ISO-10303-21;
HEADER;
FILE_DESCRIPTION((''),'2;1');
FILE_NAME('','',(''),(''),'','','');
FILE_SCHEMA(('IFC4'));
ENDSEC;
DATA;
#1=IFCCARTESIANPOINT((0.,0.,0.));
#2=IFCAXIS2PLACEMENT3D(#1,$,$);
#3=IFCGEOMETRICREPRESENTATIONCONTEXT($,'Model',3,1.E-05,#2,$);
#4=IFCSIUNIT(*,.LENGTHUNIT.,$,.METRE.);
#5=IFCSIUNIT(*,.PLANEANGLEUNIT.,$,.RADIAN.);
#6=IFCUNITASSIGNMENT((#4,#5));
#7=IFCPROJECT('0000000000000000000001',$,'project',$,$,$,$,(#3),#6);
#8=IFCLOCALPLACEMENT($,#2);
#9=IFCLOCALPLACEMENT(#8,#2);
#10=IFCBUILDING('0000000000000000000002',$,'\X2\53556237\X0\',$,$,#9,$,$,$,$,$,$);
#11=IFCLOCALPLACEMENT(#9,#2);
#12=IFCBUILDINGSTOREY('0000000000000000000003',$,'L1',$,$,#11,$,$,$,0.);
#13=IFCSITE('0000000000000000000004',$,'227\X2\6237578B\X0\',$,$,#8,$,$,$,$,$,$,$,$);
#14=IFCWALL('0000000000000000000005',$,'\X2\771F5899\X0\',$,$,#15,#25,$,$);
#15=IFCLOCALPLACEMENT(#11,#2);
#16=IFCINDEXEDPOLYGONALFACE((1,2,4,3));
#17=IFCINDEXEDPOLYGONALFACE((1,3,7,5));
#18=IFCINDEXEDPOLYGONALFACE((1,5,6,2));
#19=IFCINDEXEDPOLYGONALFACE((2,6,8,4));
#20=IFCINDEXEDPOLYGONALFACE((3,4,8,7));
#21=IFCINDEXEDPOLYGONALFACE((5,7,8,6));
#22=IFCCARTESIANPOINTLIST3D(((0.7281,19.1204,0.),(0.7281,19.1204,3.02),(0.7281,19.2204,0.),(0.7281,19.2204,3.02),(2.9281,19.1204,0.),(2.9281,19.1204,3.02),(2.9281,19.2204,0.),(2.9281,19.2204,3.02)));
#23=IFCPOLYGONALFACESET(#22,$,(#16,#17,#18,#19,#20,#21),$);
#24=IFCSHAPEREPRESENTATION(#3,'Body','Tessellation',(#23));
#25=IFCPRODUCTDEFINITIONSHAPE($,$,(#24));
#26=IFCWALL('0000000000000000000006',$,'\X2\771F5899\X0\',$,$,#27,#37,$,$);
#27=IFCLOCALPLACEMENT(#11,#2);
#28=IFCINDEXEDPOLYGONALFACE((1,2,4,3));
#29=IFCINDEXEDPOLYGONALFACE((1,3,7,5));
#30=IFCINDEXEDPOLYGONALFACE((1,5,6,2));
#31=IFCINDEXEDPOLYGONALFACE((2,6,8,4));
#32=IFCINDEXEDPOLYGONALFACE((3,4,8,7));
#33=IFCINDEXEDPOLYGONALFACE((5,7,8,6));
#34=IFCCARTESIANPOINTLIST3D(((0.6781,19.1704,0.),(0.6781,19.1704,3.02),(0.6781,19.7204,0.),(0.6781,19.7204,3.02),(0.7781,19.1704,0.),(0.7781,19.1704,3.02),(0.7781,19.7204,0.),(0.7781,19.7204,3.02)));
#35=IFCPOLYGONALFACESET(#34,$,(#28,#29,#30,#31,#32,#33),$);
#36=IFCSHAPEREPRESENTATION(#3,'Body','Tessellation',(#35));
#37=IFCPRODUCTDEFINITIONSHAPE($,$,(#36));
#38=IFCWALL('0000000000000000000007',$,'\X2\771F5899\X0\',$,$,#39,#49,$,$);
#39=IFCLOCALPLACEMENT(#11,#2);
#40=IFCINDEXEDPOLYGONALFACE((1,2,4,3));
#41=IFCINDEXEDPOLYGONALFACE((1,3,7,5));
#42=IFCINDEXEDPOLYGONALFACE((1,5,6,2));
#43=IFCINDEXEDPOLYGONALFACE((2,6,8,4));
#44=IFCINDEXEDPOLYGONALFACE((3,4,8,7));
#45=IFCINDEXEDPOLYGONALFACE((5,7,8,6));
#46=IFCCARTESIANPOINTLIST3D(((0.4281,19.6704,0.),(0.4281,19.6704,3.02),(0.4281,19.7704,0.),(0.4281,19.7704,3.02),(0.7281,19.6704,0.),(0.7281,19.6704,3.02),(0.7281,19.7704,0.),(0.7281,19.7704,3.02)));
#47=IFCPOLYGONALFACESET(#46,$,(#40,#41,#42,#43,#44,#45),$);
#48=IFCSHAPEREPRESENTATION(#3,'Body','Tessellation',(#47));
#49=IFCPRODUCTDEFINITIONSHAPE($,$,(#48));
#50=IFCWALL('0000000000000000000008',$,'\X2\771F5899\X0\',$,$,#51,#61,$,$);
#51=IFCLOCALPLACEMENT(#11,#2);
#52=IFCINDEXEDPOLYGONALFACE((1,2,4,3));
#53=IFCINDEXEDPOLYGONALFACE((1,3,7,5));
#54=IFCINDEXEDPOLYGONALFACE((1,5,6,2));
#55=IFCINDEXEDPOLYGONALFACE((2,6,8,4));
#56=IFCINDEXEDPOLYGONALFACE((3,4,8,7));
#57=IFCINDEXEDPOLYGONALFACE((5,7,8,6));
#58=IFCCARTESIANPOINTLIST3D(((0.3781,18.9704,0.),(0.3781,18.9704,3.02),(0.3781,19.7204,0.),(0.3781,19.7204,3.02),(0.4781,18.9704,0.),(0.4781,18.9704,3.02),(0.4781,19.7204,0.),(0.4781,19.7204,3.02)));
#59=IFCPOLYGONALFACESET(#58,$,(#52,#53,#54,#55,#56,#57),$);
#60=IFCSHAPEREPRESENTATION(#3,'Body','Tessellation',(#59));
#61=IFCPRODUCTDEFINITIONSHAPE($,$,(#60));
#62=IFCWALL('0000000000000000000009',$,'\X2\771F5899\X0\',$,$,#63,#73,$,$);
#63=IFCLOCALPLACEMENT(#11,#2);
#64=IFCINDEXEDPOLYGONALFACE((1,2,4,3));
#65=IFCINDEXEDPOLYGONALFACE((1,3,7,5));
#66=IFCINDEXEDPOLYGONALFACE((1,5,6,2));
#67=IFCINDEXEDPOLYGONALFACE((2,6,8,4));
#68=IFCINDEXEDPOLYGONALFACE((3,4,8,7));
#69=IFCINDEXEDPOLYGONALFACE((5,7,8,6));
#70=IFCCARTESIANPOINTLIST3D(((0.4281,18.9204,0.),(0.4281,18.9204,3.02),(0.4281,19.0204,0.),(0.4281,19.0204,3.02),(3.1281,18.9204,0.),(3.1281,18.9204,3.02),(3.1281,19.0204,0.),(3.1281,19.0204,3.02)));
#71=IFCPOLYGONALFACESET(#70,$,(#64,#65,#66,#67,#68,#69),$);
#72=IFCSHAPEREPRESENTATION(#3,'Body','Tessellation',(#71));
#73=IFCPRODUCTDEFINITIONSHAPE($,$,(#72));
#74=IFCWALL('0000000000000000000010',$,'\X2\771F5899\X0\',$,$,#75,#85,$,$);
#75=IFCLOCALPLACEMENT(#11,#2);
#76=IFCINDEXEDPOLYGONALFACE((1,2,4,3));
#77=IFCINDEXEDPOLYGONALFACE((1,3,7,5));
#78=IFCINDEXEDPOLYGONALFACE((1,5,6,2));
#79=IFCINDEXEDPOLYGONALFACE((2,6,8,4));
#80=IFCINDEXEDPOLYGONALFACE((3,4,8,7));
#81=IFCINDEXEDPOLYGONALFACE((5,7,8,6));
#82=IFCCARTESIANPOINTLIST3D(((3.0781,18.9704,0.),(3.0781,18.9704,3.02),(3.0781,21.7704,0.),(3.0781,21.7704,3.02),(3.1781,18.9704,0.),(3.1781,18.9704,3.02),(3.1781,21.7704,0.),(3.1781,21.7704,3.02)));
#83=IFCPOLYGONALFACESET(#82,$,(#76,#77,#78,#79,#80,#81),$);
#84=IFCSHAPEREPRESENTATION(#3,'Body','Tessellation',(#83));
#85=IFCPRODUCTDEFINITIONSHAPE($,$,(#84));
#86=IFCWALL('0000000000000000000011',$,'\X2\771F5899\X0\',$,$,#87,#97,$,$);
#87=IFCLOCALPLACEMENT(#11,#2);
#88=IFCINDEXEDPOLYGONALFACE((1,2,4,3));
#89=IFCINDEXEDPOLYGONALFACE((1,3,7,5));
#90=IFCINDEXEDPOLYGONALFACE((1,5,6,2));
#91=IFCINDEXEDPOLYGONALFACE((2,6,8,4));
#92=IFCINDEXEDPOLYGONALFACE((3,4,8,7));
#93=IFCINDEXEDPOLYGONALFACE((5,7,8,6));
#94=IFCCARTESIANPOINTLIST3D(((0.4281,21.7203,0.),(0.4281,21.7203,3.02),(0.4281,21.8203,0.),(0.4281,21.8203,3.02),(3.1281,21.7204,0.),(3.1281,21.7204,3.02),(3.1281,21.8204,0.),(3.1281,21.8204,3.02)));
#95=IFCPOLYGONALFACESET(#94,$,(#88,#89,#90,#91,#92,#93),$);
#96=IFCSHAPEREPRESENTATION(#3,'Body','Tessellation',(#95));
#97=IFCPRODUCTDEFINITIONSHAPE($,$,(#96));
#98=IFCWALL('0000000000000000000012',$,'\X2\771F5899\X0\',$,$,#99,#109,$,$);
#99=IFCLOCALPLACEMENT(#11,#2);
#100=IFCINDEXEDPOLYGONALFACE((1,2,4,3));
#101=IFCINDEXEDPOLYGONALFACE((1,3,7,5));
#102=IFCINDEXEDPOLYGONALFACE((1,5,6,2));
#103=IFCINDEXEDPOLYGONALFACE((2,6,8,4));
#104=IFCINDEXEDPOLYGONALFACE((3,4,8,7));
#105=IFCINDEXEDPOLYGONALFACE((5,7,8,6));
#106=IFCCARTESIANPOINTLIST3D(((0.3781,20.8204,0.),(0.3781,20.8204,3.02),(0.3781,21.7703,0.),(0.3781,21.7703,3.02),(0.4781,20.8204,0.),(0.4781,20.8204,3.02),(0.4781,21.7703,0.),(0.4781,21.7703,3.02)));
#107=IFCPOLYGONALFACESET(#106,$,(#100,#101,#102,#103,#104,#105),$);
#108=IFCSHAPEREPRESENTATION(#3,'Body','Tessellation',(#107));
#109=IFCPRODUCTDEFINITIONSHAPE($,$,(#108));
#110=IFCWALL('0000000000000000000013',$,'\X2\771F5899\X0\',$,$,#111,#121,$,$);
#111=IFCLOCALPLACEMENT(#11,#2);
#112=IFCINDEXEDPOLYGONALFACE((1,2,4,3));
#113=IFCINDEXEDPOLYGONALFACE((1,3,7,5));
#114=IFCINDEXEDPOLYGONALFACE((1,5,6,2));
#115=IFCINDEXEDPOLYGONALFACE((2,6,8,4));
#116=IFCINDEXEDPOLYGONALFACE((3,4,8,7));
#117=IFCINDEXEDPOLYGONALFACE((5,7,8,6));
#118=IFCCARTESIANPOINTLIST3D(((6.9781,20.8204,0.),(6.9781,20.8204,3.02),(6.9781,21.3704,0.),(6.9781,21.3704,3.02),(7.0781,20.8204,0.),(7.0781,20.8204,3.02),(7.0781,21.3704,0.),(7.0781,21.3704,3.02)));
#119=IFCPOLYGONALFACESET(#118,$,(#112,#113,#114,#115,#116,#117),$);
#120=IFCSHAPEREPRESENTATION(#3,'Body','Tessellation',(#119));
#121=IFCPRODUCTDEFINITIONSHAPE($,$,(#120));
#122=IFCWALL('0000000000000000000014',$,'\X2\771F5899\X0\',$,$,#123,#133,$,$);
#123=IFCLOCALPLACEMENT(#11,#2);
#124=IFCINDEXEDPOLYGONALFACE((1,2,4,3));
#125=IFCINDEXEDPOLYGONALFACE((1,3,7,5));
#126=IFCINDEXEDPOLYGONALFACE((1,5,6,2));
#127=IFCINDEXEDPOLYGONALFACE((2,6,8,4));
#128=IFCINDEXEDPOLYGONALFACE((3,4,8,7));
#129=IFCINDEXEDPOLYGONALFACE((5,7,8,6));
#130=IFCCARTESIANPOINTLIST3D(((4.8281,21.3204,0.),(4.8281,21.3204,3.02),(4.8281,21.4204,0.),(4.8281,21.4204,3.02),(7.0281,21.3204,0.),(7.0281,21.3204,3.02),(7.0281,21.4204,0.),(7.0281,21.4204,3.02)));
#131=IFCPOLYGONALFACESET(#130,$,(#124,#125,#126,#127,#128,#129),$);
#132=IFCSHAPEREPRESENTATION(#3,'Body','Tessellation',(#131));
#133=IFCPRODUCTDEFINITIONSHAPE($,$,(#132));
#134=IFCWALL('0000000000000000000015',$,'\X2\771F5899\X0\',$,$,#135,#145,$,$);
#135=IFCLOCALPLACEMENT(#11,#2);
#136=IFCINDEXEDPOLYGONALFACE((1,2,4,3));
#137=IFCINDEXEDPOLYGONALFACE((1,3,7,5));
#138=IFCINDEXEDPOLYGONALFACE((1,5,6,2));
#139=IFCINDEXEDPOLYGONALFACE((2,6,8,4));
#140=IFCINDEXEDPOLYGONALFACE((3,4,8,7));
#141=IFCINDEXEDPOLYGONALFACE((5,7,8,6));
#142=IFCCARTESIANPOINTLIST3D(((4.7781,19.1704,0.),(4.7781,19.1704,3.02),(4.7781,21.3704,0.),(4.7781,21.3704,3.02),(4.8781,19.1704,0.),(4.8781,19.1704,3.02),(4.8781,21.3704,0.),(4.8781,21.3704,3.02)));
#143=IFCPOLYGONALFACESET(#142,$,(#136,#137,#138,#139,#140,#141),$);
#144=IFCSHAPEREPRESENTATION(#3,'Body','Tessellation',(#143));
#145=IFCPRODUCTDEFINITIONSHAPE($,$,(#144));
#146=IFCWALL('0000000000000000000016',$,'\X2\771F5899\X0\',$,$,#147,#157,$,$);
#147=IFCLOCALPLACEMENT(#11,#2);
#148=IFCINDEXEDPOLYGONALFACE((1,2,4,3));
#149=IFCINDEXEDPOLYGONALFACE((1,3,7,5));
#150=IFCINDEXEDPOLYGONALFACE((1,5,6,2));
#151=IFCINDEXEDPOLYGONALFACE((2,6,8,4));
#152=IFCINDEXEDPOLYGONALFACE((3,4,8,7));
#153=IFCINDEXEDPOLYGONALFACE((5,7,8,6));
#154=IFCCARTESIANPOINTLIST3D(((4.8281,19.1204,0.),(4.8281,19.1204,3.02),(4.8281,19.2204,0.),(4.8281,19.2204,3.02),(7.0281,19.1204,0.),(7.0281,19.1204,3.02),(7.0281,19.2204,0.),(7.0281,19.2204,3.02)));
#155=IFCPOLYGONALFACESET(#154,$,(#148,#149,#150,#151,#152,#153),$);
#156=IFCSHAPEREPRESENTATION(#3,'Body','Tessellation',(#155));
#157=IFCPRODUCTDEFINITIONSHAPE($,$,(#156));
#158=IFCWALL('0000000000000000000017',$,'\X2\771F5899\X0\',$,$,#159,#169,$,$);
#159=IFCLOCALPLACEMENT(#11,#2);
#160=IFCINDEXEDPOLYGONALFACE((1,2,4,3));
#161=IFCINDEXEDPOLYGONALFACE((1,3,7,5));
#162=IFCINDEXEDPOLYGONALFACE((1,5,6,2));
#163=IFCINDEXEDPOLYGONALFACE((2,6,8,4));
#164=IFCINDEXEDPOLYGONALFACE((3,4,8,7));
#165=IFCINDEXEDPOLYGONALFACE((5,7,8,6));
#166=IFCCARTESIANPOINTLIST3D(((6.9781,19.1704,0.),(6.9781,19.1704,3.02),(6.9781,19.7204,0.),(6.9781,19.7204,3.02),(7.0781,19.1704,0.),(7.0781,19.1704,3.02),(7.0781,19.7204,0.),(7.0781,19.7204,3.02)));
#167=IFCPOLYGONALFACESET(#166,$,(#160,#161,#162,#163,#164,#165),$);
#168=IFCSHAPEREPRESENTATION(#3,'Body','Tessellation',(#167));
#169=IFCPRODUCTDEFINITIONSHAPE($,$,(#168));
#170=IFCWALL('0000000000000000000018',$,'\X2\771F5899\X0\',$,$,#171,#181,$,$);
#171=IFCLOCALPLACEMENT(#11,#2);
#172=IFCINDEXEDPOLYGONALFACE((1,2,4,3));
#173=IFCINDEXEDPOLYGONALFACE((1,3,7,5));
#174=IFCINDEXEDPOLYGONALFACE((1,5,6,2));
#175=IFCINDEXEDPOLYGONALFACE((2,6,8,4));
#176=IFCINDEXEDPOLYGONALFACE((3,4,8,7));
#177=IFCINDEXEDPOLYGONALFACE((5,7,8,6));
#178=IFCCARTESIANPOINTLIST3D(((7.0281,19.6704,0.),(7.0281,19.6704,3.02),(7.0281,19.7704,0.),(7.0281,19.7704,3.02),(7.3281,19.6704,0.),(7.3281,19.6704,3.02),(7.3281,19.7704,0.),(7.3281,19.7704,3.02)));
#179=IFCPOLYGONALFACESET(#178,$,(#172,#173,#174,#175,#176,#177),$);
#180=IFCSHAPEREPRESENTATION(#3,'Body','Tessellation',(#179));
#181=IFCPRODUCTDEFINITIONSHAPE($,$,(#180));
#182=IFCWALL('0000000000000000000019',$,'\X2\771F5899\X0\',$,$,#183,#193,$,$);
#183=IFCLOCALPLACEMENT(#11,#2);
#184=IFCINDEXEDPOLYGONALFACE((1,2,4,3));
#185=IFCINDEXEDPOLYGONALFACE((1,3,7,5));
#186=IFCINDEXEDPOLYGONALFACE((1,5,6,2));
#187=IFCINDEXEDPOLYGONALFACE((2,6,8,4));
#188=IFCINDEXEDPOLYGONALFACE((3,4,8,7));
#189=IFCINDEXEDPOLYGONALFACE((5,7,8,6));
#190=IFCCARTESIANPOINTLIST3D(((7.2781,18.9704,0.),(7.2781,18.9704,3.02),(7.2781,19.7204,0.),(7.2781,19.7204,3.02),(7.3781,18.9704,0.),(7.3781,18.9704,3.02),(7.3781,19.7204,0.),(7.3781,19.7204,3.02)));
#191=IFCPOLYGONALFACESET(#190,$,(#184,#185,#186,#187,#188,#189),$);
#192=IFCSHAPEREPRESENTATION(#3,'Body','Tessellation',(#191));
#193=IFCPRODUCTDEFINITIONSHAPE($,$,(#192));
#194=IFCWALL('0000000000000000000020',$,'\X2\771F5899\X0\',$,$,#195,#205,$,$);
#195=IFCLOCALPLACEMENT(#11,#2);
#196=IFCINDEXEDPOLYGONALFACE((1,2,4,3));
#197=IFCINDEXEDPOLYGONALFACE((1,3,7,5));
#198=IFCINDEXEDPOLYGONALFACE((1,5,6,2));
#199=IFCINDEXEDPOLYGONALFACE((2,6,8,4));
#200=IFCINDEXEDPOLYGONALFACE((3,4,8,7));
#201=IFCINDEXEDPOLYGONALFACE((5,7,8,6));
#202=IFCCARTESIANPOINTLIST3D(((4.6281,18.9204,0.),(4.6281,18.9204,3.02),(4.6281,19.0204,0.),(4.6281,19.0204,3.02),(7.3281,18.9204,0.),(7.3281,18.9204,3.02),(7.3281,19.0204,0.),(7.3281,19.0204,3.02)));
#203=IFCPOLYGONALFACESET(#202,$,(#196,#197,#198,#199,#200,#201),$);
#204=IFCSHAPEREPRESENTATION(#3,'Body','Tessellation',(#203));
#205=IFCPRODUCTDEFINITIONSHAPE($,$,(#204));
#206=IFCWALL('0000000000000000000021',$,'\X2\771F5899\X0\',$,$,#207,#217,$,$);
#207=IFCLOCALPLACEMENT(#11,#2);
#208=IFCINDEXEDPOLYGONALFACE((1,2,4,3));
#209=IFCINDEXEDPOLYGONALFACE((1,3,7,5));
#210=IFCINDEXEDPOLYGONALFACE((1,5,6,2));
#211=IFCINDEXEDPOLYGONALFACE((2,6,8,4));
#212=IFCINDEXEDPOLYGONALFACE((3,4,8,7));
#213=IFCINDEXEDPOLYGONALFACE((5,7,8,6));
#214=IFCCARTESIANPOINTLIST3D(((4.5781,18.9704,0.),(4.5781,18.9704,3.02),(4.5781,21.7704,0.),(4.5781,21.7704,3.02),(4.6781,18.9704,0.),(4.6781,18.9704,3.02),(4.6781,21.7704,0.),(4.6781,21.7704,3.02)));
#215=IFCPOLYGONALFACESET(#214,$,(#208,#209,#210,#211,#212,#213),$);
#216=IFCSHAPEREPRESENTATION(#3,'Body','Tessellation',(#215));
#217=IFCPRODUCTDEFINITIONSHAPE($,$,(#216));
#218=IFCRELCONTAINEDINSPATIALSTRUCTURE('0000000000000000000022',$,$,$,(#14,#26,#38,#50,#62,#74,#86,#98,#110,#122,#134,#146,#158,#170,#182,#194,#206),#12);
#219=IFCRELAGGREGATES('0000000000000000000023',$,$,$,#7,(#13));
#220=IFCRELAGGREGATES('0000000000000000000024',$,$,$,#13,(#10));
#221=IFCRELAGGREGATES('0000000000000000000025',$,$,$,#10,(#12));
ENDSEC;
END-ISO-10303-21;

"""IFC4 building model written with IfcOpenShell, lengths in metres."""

from ifc_helpers import new_model, si_unit, origin, place, context, project, spatial, polyline, outline, extrude, element, save


model = new_model("IFC4")

# Units and contexts
model_context = context("Model", 3, precision=1e-05, world=origin())
ifc_project = project(units=[si_unit("LENGTHUNIT", "METRE"), si_unit("PLANEANGLEUNIT", "RADIAN")], contexts=[model_context])

# Site, building, storey
site_placement = place(None, origin())
site = spatial("IfcSite", under=ifc_project, at=site_placement, Name="227户型")
building_placement = place(site_placement, origin())
building = spatial("IfcBuilding", under=site, at=building_placement, Name="单户")
storey_placement = place(building_placement, origin())
storey = spatial("IfcBuildingStorey", under=building, at=storey_placement, Name="L1", Elevation=0.0)

# Walls
wall_1_placement = place(storey_placement, origin())
element("IfcWall", 1, at=wall_1_placement, inside=storey, Name="真墙", context=model_context, shape_type="SweptSolid", body=[
    extrude(outline(polyline([(2.9281, 19.1204), (0.7281, 19.1204), (0.7281, 19.2204), (2.9281, 19.2204), (2.9281, 19.1204)])), origin(), (0.0, 0.0, 1.0), 3.02),
])
wall_2_placement = place(storey_placement, origin())
element("IfcWall", 2, at=wall_2_placement, inside=storey, Name="真墙", context=model_context, shape_type="SweptSolid", body=[
    extrude(outline(polyline([(0.6781, 19.1704), (0.6781, 19.7204), (0.7781, 19.7204), (0.7781, 19.1704), (0.6781, 19.1704)])), origin(), (0.0, 0.0, 1.0), 3.02),
])
wall_3_placement = place(storey_placement, origin())
element("IfcWall", 3, at=wall_3_placement, inside=storey, Name="真墙", context=model_context, shape_type="SweptSolid", body=[
    extrude(outline(polyline([(0.7281, 19.6704), (0.4281, 19.6704), (0.4281, 19.7704), (0.7281, 19.7704), (0.7281, 19.6704)])), origin(), (0.0, 0.0, 1.0), 3.02),
])
wall_4_placement = place(storey_placement, origin())
element("IfcWall", 4, at=wall_4_placement, inside=storey, Name="真墙", context=model_context, shape_type="SweptSolid", body=[
    extrude(outline(polyline([(0.4781, 19.7204), (0.4781, 18.9704), (0.3781, 18.9704), (0.3781, 19.7204), (0.4781, 19.7204)])), origin(), (0.0, 0.0, 1.0), 3.02),
])
wall_5_placement = place(storey_placement, origin())
element("IfcWall", 5, at=wall_5_placement, inside=storey, Name="真墙", context=model_context, shape_type="SweptSolid", body=[
    extrude(outline(polyline([(0.4281, 19.0204), (3.1281, 19.0204), (3.1281, 18.9204), (0.4281, 18.9204), (0.4281, 19.0204)])), origin(), (0.0, 0.0, 1.0), 3.02),
])
wall_6_placement = place(storey_placement, origin())
element("IfcWall", 6, at=wall_6_placement, inside=storey, Name="真墙", context=model_context, shape_type="SweptSolid", body=[
    extrude(outline(polyline([(3.0781, 18.9704), (3.0781, 21.7704), (3.1781, 21.7704), (3.1781, 18.9704), (3.0781, 18.9704)])), origin(), (0.0, 0.0, 1.0), 3.02),
])
wall_7_placement = place(storey_placement, origin())
element("IfcWall", 7, at=wall_7_placement, inside=storey, Name="真墙", context=model_context, shape_type="SweptSolid", body=[
    extrude(outline(polyline([(3.1281, 21.7204), (0.4281, 21.7203), (0.4281, 21.8203), (3.1281, 21.8204), (3.1281, 21.7204)])), origin(), (0.0, 0.0, 1.0), 3.02),
])
wall_8_placement = place(storey_placement, origin())
element("IfcWall", 8, at=wall_8_placement, inside=storey, Name="真墙", context=model_context, shape_type="SweptSolid", body=[
    extrude(outline(polyline([(0.4781, 21.7703), (0.4781, 20.8204), (0.3781, 20.8204), (0.3781, 21.7703), (0.4781, 21.7703)])), origin(), (0.0, 0.0, 1.0), 3.02),
])
wall_9_placement = place(storey_placement, origin())
element("IfcWall", 9, at=wall_9_placement, inside=storey, Name="真墙", context=model_context, shape_type="SweptSolid", body=[
    extrude(outline(polyline([(6.9781, 20.8204), (6.9781, 21.3704), (7.0781, 21.3704), (7.0781, 20.8204), (6.9781, 20.8204)])), origin(), (0.0, 0.0, 1.0), 3.02),
])
wall_10_placement = place(storey_placement, origin())
element("IfcWall", 10, at=wall_10_placement, inside=storey, Name="真墙", context=model_context, shape_type="SweptSolid", body=[
    extrude(outline(polyline([(7.0281, 21.3204), (4.8281, 21.3204), (4.8281, 21.4204), (7.0281, 21.4204), (7.0281, 21.3204)])), origin(), (0.0, 0.0, 1.0), 3.02),
])
wall_11_placement = place(storey_placement, origin())
element("IfcWall", 11, at=wall_11_placement, inside=storey, Name="真墙", context=model_context, shape_type="SweptSolid", body=[
    extrude(outline(polyline([(4.8781, 21.3704), (4.8781, 19.1704), (4.7781, 19.1704), (4.7781, 21.3704), (4.8781, 21.3704)])), origin(), (0.0, 0.0, 1.0), 3.02),
])
wall_12_placement = place(storey_placement, origin())
element("IfcWall", 12, at=wall_12_placement, inside=storey, Name="真墙", context=model_context, shape_type="SweptSolid", body=[
    extrude(outline(polyline([(4.8281, 19.2204), (7.0281, 19.2204), (7.0281, 19.1204), (4.8281, 19.1204), (4.8281, 19.2204)])), origin(), (0.0, 0.0, 1.0), 3.02),
])
wall_13_placement = place(storey_placement, origin())
element("IfcWall", 13, at=wall_13_placement, inside=storey, Name="真墙", context=model_context, shape_type="SweptSolid", body=[
    extrude(outline(polyline([(6.9781, 19.1704), (6.9781, 19.7204), (7.0781, 19.7204), (7.0781, 19.1704), (6.9781, 19.1704)])), origin(), (0.0, 0.0, 1.0), 3.02),
])
wall_14_placement = place(storey_placement, origin())
element("IfcWall", 14, at=wall_14_placement, inside=storey, Name="真墙", context=model_context, shape_type="SweptSolid", body=[
    extrude(outline(polyline([(7.0281, 19.7704), (7.3281, 19.7704), (7.3281, 19.6704), (7.0281, 19.6704), (7.0281, 19.7704)])), origin(), (0.0, 0.0, 1.0), 3.02),
])
wall_15_placement = place(storey_placement, origin())
element("IfcWall", 15, at=wall_15_placement, inside=storey, Name="真墙", context=model_context, shape_type="SweptSolid", body=[
    extrude(outline(polyline([(7.3781, 19.7204), (7.3781, 18.9704), (7.2781, 18.9704), (7.2781, 19.7204), (7.3781, 19.7204)])), origin(), (0.0, 0.0, 1.0), 3.02),
])
wall_16_placement = place(storey_placement, origin())
element("IfcWall", 16, at=wall_16_placement, inside=storey, Name="真墙", context=model_context, shape_type="SweptSolid", body=[
    extrude(outline(polyline([(7.3281, 18.9204), (4.6281, 18.9204), (4.6281, 19.0204), (7.3281, 19.0204), (7.3281, 18.9204)])), origin(), (0.0, 0.0, 1.0), 3.02),
])
wall_17_placement = place(storey_placement, origin())
element("IfcWall", 17, at=wall_17_placement, inside=storey, Name="真墙", context=model_context, shape_type="SweptSolid", body=[
    extrude(outline(polyline([(4.5781, 18.9704), (4.5781, 21.7704), (4.6781, 21.7704), (4.6781, 18.9704), (4.5781, 18.9704)])), origin(), (0.0, 0.0, 1.0), 3.02),
])

save(model, "model.ifc")
